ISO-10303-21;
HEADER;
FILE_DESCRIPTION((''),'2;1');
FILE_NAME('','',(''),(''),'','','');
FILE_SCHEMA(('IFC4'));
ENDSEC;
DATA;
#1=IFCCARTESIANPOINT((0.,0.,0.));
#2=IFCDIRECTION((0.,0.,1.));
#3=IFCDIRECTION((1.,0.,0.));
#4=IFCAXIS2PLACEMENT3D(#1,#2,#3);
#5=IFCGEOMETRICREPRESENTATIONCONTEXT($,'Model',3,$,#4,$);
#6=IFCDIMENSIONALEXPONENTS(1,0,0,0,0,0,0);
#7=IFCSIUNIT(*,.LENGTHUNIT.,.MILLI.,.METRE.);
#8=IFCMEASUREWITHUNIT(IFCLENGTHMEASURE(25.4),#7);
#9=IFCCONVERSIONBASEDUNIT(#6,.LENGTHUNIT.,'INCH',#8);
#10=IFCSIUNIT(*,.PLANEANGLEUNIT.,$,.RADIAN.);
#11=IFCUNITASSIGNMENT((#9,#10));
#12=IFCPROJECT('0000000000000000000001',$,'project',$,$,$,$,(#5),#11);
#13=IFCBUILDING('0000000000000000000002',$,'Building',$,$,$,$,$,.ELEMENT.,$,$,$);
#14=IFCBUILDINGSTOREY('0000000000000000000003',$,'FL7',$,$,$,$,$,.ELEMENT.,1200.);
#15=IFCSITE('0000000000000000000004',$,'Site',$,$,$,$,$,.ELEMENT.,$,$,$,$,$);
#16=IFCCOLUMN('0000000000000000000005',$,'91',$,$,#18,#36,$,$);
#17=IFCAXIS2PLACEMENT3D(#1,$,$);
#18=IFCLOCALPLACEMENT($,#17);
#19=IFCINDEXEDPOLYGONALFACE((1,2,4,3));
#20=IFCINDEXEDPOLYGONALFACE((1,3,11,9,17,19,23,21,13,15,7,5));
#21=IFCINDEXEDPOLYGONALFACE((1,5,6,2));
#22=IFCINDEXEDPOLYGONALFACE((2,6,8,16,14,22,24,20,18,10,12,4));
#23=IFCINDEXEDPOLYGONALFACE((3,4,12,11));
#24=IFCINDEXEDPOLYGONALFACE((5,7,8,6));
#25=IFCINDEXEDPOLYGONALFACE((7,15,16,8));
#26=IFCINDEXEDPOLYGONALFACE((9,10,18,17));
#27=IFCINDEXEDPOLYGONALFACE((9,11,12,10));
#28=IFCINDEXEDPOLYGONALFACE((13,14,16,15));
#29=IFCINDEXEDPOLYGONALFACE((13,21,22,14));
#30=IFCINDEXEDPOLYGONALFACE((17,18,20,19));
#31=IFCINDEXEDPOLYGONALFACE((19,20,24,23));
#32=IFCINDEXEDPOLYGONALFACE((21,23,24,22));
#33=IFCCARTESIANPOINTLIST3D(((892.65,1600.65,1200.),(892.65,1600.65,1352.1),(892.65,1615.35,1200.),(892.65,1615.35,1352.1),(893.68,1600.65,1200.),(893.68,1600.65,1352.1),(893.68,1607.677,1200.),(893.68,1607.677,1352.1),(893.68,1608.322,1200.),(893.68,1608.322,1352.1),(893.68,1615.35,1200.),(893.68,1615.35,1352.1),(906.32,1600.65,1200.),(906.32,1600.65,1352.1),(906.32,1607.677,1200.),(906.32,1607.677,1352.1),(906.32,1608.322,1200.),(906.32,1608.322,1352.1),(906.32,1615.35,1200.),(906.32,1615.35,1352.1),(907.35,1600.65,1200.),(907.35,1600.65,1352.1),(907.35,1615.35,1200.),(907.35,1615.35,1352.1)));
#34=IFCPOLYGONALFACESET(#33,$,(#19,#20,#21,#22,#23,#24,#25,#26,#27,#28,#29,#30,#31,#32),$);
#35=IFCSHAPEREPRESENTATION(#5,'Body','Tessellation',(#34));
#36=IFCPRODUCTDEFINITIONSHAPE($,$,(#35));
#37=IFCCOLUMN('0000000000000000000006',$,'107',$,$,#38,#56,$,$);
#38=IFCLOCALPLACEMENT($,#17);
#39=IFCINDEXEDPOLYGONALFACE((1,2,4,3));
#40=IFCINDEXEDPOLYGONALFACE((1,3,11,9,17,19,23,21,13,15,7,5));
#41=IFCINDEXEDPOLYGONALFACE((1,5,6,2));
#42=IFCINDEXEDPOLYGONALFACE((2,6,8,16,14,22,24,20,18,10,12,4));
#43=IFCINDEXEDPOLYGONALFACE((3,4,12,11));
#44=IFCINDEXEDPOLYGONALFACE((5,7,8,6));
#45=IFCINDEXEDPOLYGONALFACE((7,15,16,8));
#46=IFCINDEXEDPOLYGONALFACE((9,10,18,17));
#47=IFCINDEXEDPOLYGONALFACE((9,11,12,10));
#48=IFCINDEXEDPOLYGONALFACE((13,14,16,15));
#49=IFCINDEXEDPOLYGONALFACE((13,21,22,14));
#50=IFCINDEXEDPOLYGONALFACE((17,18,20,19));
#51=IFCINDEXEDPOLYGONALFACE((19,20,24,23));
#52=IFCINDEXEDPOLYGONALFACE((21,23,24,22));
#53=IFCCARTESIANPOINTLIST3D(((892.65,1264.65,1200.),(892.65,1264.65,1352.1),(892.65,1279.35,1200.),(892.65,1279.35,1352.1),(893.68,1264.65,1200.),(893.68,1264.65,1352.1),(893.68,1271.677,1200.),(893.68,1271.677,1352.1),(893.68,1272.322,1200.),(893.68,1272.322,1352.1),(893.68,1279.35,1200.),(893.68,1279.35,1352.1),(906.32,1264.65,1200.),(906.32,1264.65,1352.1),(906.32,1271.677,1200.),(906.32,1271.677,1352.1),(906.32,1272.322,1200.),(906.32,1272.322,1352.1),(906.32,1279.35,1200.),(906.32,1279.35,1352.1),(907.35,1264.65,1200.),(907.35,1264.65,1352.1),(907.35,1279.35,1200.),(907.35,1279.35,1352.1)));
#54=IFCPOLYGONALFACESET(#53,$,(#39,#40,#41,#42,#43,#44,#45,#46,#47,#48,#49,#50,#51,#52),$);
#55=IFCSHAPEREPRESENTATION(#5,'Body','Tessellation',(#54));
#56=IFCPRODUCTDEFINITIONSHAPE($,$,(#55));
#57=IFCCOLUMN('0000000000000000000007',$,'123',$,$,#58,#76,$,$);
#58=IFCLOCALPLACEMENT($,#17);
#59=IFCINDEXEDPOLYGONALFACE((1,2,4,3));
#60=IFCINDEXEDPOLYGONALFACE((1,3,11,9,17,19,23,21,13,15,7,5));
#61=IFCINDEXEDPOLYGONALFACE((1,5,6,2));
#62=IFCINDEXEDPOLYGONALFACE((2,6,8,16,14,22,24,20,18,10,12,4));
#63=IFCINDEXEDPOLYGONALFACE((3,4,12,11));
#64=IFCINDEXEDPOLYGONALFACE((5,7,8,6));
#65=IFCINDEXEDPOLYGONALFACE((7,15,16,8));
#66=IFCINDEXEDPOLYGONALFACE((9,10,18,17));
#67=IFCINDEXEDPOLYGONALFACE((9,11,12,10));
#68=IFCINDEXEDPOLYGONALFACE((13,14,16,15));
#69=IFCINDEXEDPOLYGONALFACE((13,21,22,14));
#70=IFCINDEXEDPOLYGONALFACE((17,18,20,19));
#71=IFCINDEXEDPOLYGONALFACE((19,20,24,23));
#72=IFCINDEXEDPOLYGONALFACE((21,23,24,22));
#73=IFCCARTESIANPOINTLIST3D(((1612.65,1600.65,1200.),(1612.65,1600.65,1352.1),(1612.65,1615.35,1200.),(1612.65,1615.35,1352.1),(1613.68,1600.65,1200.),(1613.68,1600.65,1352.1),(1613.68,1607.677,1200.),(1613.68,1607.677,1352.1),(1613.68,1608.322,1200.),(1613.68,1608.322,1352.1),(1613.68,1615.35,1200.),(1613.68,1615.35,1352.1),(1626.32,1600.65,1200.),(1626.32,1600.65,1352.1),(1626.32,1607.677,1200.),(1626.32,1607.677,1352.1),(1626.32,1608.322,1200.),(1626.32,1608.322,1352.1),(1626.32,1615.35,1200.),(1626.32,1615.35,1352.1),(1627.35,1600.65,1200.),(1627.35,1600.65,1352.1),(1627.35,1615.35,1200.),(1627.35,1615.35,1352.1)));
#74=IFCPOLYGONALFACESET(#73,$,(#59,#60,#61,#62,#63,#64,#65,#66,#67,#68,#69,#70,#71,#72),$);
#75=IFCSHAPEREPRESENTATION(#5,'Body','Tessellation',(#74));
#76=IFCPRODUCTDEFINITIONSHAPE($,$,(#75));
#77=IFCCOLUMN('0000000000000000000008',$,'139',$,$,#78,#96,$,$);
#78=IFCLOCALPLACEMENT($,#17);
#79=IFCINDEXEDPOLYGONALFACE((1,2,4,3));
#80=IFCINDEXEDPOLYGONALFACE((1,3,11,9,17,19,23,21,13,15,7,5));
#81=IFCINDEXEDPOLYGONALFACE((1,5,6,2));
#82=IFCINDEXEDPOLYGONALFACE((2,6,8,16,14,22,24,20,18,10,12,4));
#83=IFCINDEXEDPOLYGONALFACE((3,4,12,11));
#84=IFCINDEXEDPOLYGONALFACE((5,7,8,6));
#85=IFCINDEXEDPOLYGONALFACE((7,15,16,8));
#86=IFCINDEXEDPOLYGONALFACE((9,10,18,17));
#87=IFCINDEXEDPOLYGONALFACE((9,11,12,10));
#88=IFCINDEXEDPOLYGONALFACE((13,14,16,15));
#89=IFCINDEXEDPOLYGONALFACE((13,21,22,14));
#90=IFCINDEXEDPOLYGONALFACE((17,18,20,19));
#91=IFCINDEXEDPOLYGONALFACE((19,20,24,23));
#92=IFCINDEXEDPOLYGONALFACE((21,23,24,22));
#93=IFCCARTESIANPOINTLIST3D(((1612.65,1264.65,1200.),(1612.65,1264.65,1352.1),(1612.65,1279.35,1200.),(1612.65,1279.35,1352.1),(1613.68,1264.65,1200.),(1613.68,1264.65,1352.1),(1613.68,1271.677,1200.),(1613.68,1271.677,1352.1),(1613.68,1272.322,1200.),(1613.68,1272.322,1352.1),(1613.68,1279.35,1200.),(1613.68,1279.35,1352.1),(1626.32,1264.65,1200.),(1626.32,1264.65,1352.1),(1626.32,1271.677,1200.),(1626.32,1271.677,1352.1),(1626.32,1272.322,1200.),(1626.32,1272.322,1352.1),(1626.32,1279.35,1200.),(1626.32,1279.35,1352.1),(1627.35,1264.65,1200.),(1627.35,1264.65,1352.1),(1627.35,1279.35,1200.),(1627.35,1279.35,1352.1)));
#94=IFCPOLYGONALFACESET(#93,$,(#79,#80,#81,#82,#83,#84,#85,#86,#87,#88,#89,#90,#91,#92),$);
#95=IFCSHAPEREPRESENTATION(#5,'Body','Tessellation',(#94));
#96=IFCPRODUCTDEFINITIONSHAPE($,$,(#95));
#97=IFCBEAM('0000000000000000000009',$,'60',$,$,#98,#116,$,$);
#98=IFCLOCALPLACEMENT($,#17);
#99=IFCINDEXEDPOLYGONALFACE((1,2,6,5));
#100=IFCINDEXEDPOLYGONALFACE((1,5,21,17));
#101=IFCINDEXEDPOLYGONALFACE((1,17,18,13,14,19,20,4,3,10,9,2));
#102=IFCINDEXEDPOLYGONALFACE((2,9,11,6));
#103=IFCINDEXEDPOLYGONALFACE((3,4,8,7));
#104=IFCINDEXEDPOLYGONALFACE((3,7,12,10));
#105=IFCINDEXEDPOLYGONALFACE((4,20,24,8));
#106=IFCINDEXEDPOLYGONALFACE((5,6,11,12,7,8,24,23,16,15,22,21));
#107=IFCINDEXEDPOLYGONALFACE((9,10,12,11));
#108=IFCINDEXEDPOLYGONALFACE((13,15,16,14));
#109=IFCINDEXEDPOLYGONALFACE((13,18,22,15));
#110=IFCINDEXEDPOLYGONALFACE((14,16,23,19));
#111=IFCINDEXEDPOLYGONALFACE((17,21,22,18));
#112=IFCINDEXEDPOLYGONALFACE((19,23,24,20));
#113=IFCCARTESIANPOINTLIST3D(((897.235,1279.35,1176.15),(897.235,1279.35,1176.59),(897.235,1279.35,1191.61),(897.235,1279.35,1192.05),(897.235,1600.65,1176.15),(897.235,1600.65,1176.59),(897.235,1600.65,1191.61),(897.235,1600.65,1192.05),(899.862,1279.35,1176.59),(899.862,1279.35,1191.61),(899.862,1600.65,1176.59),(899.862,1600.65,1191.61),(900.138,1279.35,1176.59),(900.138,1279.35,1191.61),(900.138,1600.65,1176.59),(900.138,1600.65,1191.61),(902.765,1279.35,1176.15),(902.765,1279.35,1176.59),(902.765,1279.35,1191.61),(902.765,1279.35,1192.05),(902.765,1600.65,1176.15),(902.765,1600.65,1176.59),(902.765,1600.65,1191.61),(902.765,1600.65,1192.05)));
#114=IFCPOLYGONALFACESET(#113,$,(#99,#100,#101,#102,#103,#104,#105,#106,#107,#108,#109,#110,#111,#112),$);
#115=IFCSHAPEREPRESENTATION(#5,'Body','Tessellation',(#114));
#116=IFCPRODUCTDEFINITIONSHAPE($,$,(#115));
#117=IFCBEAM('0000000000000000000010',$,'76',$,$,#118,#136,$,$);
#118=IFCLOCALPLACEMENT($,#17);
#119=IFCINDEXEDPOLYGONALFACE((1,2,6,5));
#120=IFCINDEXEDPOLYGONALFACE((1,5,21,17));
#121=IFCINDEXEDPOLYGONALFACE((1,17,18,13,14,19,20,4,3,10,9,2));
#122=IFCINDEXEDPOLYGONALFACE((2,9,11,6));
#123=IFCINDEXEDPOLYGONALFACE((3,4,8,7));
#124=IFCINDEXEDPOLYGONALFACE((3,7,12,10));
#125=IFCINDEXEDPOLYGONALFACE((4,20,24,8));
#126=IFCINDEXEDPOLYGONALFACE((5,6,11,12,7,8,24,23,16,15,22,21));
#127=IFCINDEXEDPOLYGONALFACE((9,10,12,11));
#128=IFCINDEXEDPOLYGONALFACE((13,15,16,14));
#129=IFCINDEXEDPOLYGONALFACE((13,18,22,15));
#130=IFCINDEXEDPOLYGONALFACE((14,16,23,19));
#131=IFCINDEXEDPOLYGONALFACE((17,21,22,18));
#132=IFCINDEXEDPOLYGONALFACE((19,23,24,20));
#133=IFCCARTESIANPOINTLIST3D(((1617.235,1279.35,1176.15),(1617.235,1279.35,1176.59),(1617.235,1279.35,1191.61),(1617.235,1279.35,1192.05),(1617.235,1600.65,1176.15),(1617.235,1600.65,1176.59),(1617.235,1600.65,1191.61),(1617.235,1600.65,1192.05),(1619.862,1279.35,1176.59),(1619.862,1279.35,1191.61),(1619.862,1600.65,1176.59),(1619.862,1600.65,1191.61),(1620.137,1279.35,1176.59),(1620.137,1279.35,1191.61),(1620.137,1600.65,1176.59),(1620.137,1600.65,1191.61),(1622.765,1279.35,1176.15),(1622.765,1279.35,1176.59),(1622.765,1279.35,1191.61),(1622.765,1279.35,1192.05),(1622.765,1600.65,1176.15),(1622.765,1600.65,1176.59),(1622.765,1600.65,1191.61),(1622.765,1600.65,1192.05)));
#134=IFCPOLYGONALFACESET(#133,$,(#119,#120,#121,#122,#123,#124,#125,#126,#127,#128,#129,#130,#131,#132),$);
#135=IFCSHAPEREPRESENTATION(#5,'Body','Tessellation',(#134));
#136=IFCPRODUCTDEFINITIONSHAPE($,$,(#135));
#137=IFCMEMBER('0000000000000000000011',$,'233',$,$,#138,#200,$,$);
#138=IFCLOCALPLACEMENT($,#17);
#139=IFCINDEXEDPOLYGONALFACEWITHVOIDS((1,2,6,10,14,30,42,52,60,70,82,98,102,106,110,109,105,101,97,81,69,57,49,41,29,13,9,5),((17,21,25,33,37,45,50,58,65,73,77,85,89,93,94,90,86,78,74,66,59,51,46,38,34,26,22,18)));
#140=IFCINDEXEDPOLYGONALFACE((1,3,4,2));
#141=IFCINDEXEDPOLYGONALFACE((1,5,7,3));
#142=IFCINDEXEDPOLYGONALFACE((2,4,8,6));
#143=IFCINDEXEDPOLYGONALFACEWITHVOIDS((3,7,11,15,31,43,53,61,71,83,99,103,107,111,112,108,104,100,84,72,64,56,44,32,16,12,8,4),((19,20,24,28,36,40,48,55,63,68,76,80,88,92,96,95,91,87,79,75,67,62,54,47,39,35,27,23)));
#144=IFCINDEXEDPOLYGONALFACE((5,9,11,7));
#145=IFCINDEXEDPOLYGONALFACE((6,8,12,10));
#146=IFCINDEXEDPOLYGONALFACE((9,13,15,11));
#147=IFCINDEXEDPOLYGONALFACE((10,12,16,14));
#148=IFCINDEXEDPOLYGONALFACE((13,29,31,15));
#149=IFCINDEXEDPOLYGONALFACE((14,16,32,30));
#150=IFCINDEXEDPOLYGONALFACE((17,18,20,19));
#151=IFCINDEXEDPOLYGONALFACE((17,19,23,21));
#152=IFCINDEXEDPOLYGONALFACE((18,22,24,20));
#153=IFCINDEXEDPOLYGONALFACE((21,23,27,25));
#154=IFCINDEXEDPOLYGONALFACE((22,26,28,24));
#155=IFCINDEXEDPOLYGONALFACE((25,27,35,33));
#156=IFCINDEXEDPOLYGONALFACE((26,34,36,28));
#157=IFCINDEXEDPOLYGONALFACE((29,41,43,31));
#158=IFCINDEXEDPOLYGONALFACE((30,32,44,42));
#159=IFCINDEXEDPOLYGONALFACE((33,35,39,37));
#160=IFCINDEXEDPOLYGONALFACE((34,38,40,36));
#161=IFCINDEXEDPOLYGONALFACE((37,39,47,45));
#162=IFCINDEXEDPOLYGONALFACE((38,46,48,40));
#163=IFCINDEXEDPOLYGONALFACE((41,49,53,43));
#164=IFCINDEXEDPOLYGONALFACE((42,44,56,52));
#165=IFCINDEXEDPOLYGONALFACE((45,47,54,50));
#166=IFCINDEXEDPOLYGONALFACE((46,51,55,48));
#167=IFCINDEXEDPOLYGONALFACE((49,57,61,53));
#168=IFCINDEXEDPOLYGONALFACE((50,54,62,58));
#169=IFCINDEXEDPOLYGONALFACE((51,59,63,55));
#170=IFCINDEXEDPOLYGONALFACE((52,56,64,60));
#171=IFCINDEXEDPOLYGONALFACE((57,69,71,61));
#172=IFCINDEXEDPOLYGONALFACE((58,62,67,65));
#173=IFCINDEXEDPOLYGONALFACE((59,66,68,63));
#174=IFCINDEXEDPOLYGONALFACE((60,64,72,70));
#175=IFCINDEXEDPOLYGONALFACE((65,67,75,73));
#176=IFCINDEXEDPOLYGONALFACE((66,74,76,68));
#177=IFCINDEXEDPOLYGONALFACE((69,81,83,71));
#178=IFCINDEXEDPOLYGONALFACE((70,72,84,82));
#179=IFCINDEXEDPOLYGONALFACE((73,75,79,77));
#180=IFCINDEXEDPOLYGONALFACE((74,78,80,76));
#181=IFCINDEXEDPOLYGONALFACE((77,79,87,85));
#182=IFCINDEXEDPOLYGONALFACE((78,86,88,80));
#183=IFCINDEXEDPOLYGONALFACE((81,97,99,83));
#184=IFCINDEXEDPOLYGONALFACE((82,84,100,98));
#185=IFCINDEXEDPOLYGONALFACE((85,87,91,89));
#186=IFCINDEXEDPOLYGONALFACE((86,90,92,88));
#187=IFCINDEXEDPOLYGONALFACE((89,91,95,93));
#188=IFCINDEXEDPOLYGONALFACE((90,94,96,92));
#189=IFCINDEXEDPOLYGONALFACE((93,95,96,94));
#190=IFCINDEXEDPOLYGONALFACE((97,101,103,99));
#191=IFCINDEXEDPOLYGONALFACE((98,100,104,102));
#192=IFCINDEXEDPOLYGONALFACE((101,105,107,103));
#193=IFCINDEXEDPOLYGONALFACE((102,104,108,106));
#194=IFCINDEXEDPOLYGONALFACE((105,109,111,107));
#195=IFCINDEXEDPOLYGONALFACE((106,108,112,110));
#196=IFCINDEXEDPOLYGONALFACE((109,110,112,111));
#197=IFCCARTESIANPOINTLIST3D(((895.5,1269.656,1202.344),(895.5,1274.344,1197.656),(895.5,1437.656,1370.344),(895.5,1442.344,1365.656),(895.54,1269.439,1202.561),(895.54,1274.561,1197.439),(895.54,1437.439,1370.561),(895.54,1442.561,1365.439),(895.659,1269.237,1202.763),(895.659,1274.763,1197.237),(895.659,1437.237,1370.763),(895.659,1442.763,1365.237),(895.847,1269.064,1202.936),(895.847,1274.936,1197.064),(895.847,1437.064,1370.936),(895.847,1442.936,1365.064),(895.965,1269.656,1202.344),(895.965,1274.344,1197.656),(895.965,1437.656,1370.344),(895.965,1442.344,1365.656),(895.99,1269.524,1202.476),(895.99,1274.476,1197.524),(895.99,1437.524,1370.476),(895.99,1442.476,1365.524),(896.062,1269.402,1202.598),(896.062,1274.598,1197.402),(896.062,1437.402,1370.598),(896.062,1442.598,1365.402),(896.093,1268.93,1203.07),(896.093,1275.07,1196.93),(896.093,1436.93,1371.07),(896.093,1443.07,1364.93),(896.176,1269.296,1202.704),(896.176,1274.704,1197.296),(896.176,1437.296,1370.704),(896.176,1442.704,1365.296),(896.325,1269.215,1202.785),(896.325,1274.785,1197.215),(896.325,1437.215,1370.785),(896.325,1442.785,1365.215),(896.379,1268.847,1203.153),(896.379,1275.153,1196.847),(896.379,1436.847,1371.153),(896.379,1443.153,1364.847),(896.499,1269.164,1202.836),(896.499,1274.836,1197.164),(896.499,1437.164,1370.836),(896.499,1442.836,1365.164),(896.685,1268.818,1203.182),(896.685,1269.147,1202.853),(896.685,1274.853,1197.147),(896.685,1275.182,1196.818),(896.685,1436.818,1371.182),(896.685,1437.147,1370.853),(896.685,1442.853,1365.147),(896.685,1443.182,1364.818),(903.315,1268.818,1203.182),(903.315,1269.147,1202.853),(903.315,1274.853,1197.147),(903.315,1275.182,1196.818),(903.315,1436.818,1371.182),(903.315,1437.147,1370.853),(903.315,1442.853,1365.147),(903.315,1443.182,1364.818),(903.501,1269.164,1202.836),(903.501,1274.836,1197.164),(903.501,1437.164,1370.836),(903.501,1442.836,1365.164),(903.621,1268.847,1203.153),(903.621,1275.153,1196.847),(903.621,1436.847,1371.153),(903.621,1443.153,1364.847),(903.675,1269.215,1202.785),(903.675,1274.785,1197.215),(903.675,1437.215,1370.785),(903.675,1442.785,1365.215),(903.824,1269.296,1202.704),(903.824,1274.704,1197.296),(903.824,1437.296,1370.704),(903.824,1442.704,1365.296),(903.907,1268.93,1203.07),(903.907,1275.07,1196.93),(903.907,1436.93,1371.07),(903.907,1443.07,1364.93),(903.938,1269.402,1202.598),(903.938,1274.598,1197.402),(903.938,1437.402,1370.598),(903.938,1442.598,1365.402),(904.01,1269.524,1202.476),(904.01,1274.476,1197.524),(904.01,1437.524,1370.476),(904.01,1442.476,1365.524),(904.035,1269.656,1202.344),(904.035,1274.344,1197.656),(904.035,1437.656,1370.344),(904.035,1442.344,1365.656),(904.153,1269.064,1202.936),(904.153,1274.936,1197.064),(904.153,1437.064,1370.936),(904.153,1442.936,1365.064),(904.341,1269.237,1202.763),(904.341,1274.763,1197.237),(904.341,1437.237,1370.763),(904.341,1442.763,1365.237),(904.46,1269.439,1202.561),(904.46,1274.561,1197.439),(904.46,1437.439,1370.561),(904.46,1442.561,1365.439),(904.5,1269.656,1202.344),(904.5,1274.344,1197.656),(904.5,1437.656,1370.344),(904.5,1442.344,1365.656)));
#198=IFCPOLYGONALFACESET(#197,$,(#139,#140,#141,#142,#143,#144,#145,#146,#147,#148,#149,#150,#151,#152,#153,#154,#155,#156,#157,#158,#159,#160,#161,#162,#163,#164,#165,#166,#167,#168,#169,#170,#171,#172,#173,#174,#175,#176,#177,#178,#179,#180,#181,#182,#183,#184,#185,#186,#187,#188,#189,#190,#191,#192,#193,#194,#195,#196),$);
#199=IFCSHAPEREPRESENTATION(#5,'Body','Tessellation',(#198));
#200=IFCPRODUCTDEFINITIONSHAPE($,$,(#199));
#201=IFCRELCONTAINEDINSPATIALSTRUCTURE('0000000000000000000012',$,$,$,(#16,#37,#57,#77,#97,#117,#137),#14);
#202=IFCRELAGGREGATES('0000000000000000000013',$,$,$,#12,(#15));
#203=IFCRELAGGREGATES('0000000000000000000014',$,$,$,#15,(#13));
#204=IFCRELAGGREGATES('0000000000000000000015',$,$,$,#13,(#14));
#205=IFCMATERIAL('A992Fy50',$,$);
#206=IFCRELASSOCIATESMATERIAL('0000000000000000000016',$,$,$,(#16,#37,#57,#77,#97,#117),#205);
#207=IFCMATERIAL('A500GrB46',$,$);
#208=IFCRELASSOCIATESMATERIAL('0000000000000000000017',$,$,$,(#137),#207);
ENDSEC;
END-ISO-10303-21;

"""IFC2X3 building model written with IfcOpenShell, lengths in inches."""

from ifc_helpers import new_model, entity, si_unit, converted_unit, frame, origin_with_axes, origin_2d_with_axis, place, context, project, spatial, hollow_rectangle, i_section, transform_2d, derived_profile, extrude, material, element, save


model = new_model("IFC2X3")

# Units and contexts
model_context = context("Model", 3, world=origin_with_axes())
ifc_project = project(units=[converted_unit("LENGTHUNIT", "INCH", entity("IfcLengthMeasure", 25.4), si_unit("LENGTHUNIT", "METRE", prefix="MILLI"), dimensions=[1, 0, 0, 0, 0, 0, 0]), si_unit("PLANEANGLEUNIT", "RADIAN")], contexts=[model_context])

# Site, building, storey
site = spatial("IfcSite", under=ifc_project, Name="Site", CompositionType="ELEMENT")
building = spatial("IfcBuilding", under=site, Name="Building", CompositionType="ELEMENT")
storey = spatial("IfcBuildingStorey", under=building, Name="FL7", CompositionType="ELEMENT", Elevation=1200.0)

# Columns
ifc_material_1 = material(Name="A992Fy50")
for number, where, z_axis, x_axis, name in (
    (1, (900.0, 1608.0, 1200.0), (0.0, 0.0, 1.0), (0.0, -1.0, 0.0), "91"),
    (2, (900.0, 1272.0, 1200.0), (0.0, 0.0, 1.0), (0.0, -1.0, 0.0), "107"),
    (3, (1620.0, 1608.0, 1200.0), (0.0, 0.0, 1.0), (0.0, -1.0, 0.0), "123"),
    (4, (1620.0, 1272.0, 1200.0), (0.0, 0.0, 1.0), (0.0, -1.0, 0.0), "139"),
):
    element("IfcColumn", number, at=place(None, frame(where, z_axis=z_axis, x_axis=x_axis)), inside=storey, material=ifc_material_1, Name=name, context=model_context, shape_type="SweptSolid", body=[
        extrude(i_section(OverallWidth=14.7, OverallDepth=14.7, WebThickness=0.645, FlangeThickness=1.03, at=origin_2d_with_axis()), origin_with_axes(), (0.0, 0.0, 1.0), 152.1),
    ])

# Beams
for number, where, z_axis, x_axis, name in (
    (5, (900.0, 1279.35, 1200.0), (0.0, 1.0, 0.0), (-1.0, 0.0, 0.0), "60"),
    (6, (1620.0, 1279.35, 1200.0), (0.0, 1.0, 0.0), (-1.0, 0.0, 0.0), "76"),
):
    element("IfcBeam", number, at=place(None, frame(where, z_axis=z_axis, x_axis=x_axis)), inside=storey, material=ifc_material_1, Name=name, context=model_context, shape_type="SweptSolid", body=[
        extrude(derived_profile(i_section(OverallWidth=5.53, OverallDepth=15.9, WebThickness=0.275, FlangeThickness=0.44, at=origin_2d_with_axis()), transform_2d((0.0, -7.95))), origin_with_axes(), (0.0, 0.0, 1.0), 321.3),
    ])

# Member
ifc_material_2 = material(Name="A500GrB46")
for number, where, z_axis, x_axis, name in (
    (7, (900.0, 1272.0, 1200.0), (0.0, 0.707107, 0.707107), (-1.0, 0.0, 0.0), "233"),
):
    element("IfcMember", number, at=place(None, frame(where, z_axis=z_axis, x_axis=x_axis)), inside=storey, material=ifc_material_2, Name=name, context=model_context, shape_type="SweptSolid", body=[
        extrude(hollow_rectangle(XDim=9.0, YDim=9.0, WallThickness=0.465, InnerFilletRadius=0.72, OuterFilletRadius=1.185, at=origin_2d_with_axis()), origin_with_axes(), (0.0, 0.0, 1.0), 237.588),
    ])

save(model, "model.ifc")
